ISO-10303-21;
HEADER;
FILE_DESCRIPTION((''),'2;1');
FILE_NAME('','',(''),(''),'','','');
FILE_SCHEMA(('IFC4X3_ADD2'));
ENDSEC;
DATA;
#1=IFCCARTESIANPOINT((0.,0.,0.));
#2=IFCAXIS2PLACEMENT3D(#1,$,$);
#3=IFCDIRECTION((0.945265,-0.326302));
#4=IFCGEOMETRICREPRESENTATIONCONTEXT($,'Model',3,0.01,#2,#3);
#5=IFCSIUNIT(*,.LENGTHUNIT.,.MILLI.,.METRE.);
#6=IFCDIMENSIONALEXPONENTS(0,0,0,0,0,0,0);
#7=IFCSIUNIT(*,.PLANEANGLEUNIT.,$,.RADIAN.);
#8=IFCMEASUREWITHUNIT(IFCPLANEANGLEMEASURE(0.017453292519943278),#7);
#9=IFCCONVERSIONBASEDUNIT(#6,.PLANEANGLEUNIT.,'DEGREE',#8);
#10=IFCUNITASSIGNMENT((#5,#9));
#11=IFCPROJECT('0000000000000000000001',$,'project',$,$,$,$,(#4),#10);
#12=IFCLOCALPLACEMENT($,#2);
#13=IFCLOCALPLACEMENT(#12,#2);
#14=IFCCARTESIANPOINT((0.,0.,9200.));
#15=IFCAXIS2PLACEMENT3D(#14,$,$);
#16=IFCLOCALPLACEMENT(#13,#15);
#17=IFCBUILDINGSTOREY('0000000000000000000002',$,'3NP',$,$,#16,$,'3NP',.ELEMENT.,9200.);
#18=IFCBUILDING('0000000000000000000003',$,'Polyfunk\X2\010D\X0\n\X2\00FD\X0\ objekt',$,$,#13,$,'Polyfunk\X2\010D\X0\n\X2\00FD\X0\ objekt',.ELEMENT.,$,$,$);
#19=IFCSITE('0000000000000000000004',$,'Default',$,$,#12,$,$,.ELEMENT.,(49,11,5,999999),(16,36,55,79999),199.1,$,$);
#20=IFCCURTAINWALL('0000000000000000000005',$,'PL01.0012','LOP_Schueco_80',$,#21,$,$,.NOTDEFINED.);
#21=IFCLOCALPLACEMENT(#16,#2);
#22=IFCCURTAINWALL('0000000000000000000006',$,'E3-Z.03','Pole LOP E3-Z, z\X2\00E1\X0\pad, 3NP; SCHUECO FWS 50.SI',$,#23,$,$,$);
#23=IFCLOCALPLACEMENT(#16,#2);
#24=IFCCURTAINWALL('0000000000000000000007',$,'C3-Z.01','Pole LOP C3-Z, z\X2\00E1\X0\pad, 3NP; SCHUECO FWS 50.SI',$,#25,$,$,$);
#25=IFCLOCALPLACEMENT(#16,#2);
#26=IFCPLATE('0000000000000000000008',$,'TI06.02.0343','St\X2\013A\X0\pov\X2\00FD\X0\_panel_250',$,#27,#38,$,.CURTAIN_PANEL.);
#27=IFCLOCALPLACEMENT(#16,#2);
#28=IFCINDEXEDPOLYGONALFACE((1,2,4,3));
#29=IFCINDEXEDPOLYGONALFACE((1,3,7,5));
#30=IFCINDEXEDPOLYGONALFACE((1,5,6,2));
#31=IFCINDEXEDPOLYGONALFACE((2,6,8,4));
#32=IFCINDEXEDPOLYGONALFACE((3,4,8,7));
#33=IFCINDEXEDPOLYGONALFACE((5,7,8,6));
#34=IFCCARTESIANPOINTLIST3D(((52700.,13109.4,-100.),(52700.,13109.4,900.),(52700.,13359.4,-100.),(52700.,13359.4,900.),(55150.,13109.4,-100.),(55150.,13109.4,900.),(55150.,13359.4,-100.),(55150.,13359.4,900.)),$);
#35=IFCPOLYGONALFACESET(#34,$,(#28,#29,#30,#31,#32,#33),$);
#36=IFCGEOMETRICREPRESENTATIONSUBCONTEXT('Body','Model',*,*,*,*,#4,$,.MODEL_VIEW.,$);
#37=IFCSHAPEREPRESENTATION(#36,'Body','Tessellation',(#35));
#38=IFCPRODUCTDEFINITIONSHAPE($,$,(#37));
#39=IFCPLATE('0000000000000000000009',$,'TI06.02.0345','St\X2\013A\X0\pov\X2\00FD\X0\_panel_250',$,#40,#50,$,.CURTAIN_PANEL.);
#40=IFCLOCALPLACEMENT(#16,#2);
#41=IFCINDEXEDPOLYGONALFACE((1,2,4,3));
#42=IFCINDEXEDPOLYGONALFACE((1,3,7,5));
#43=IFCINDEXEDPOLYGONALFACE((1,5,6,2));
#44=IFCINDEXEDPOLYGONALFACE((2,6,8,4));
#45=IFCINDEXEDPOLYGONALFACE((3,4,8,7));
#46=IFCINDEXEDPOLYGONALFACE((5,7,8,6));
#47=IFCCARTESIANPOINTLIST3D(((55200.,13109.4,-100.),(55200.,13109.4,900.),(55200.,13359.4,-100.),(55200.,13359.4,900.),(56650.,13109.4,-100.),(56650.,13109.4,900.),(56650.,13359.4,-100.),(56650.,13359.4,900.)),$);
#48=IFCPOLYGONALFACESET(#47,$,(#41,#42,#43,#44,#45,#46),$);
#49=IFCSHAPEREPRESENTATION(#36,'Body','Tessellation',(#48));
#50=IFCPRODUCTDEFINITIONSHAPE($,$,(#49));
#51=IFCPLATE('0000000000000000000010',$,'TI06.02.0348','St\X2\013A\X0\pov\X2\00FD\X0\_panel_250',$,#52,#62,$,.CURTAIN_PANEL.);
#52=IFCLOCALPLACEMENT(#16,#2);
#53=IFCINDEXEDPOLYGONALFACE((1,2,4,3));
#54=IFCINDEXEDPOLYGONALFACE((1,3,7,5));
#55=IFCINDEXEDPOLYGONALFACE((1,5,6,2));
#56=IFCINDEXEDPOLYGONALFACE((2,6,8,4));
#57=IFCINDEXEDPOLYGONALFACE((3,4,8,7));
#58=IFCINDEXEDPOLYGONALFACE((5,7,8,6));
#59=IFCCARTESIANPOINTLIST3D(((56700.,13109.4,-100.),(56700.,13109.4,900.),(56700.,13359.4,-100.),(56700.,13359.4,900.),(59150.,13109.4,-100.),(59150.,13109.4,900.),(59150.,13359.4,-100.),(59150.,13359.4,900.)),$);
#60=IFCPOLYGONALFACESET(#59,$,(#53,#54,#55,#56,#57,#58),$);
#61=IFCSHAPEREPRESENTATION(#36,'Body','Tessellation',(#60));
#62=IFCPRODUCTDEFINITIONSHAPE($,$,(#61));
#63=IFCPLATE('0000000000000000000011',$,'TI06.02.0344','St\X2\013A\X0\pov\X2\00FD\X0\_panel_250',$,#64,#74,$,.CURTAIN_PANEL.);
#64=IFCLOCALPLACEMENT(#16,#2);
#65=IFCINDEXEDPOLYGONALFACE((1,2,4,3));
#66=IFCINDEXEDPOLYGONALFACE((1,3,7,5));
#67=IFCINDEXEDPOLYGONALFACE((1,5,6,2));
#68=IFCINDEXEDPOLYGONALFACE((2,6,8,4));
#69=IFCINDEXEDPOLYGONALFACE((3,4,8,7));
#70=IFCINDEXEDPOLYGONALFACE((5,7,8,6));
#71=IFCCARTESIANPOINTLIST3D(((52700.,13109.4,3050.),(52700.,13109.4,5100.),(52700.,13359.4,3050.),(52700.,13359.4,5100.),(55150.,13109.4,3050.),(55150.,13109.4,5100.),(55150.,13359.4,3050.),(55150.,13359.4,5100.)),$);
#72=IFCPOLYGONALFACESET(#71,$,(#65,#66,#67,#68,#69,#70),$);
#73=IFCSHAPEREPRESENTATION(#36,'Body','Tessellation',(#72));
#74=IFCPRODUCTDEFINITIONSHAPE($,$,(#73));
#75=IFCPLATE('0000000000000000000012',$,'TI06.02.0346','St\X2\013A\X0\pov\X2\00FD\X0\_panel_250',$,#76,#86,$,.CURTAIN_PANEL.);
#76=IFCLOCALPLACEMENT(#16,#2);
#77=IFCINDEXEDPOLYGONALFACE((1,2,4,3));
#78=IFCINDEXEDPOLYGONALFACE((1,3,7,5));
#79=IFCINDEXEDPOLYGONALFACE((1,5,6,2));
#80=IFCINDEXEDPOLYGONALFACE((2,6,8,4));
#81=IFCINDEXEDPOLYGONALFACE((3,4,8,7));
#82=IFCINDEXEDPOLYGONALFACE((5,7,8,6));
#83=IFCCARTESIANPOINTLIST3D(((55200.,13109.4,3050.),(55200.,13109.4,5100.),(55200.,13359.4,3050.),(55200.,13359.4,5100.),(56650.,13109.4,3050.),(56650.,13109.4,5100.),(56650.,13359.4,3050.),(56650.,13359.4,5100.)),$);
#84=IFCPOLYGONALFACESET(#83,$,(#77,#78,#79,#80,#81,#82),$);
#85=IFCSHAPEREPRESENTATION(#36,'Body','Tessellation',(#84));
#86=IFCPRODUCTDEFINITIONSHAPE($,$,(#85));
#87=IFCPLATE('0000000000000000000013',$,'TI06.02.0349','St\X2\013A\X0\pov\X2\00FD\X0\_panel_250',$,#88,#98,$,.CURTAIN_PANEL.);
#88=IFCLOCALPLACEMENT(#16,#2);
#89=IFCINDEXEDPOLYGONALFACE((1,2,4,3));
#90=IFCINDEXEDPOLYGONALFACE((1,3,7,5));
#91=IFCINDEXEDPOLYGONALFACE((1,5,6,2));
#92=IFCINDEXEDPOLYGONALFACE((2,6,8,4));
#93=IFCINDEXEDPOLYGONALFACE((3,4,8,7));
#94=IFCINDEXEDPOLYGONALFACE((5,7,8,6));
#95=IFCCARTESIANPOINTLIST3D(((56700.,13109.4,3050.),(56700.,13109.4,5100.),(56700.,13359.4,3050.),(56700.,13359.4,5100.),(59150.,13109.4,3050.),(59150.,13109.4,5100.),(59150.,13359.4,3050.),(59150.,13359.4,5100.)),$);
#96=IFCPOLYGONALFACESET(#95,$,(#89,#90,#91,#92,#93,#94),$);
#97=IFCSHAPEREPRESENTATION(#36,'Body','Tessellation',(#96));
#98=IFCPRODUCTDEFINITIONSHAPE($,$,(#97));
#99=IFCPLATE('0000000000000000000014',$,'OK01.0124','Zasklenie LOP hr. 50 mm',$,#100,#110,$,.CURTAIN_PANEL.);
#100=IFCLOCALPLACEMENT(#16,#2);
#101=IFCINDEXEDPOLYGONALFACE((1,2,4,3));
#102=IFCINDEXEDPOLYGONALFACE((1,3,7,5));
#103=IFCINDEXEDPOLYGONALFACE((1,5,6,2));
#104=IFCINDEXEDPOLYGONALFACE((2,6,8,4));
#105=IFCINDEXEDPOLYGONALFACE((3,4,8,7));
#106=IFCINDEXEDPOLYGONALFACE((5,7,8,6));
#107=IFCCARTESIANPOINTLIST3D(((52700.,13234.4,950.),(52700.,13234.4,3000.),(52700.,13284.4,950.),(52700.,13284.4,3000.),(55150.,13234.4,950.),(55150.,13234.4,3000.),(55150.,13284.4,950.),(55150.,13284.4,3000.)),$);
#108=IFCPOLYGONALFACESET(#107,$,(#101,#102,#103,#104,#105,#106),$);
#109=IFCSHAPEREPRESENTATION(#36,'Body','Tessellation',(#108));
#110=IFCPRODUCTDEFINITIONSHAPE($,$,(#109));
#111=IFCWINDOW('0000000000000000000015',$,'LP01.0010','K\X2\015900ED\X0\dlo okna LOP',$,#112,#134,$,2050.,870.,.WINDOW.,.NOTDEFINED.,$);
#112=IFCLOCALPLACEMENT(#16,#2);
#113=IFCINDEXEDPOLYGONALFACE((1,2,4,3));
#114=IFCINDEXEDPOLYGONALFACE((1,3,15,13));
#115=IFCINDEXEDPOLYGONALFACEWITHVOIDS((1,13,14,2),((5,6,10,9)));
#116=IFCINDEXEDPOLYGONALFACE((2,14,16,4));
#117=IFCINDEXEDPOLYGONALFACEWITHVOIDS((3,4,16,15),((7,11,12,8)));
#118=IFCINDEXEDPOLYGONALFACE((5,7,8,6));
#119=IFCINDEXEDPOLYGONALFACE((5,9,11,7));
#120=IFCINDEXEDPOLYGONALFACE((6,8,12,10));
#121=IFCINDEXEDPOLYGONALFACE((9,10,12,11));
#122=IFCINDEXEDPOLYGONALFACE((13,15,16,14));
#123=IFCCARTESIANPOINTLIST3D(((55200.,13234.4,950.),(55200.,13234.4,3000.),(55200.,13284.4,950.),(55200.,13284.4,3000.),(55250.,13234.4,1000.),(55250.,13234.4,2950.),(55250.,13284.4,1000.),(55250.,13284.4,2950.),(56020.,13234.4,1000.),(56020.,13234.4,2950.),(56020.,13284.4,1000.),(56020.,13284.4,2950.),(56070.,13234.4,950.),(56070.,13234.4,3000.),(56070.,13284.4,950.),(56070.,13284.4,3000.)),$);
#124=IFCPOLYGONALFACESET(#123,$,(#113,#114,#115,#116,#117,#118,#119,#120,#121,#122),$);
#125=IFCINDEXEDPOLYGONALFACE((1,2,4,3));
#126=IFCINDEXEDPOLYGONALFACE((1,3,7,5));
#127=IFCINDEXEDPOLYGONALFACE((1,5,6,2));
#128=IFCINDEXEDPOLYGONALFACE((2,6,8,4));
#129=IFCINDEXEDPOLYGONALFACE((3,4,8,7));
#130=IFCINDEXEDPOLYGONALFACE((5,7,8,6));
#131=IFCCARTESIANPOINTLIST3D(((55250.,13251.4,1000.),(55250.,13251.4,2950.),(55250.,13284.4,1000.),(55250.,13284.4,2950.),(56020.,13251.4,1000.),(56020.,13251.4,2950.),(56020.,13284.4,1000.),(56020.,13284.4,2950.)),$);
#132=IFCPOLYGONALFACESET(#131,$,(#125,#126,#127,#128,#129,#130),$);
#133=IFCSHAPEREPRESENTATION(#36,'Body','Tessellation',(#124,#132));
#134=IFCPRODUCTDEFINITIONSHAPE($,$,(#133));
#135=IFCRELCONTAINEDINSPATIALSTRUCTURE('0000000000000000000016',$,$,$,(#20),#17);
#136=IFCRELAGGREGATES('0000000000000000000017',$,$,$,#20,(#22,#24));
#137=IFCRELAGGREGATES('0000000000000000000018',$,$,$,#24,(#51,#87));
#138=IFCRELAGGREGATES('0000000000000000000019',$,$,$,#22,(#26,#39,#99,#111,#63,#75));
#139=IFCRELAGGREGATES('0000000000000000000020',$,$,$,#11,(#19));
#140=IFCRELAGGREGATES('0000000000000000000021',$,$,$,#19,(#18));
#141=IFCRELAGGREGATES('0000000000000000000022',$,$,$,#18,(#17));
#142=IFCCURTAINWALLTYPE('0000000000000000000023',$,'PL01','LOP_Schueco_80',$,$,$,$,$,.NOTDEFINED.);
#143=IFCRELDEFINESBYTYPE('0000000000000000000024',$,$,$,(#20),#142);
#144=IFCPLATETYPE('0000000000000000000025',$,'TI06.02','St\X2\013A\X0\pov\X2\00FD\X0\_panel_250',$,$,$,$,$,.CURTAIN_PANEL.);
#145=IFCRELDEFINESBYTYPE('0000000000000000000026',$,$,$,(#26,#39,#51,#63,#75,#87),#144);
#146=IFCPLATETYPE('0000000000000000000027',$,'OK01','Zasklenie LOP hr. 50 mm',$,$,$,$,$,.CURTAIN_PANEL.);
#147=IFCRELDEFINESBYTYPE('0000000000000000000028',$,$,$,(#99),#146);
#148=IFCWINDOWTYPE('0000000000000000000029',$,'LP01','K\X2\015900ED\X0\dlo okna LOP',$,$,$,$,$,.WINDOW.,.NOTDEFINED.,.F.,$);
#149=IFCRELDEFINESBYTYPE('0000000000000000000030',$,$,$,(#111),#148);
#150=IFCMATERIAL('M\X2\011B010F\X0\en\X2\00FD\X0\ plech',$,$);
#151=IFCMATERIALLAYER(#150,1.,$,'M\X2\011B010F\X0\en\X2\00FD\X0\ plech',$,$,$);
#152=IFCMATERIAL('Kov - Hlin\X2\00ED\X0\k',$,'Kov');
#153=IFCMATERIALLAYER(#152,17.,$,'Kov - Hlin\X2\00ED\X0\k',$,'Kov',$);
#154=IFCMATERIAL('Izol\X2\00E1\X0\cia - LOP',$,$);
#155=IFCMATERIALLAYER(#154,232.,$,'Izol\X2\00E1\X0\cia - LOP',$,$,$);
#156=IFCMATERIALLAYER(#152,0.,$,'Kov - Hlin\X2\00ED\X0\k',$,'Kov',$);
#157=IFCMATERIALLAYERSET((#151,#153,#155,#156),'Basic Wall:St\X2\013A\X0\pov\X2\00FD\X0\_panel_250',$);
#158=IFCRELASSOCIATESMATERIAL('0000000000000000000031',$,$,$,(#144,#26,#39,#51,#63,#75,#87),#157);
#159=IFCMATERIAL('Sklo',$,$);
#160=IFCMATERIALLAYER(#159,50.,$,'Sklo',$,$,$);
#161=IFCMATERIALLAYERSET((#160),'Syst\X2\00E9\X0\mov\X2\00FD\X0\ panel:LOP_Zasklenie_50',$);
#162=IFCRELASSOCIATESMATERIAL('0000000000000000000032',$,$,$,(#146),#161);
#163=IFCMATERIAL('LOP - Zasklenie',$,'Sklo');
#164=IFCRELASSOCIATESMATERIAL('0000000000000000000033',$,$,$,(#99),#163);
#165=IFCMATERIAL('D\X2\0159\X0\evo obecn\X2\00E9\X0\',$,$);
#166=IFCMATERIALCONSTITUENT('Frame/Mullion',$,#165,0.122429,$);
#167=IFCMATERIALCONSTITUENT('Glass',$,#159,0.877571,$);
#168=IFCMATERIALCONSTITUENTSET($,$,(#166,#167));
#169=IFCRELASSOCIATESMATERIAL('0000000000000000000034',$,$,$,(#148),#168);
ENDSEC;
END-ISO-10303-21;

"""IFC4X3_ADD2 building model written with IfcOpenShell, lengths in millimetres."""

from ifc_helpers import new_model, entity, si_unit, converted_unit, direction, frame, frame_2d, origin, origin_2d_with_axis, place, context, subcontext, project, spatial, polyline, rectangle, outline, extrude, source, transform, mapped, material, layer, layer_set, layer_usage, constituent, constituent_set, type_object, type_shapes, element, aggregate, save


model = new_model("IFC4X3_ADD2")

# Units and contexts
model_context = context("Model", 3, precision=0.01, world=origin(), true_north=direction((0.945265, -0.326302)))
body_context = subcontext(model_context, "Body", "Model", "MODEL_VIEW")
ifc_project = project(units=[si_unit("LENGTHUNIT", "METRE", prefix="MILLI"), converted_unit("PLANEANGLEUNIT", "DEGREE", entity("IfcPlaneAngleMeasure", 0.017453292519943278), si_unit("PLANEANGLEUNIT", "RADIAN"), dimensions=[0, 0, 0, 0, 0, 0, 0])], contexts=[model_context])

# Site, building, storey
site_placement = place(None, origin())
site = spatial("IfcSite", under=ifc_project, at=site_placement, Name="Default", CompositionType="ELEMENT", RefLatitude=(49, 11, 5, 999999), RefLongitude=(16, 36, 55, 79999), RefElevation=199.1)
building_placement = place(site_placement, origin())
building = spatial("IfcBuilding", under=site, at=building_placement, Name="Polyfunkčný objekt", LongName="Polyfunkčný objekt", CompositionType="ELEMENT")
storey_placement = place(building_placement, frame((0.0, 0.0, 9200.0)))
storey = spatial("IfcBuildingStorey", under=building, at=storey_placement, Name="3NP", LongName="3NP", CompositionType="ELEMENT", Elevation=9200.0)

# Curtain walls, plates, window
curtain_wall_type = type_object("IfcCurtainWallType", Name="PL01", Description="LOP_Schueco_80", PredefinedType="NOTDEFINED")
curtain_wall_1_placement = place(storey_placement, frame((0.0, 0.0, -9200.0)))
curtain_wall_1 = element("IfcCurtainWall", 1, at=curtain_wall_1_placement, inside=storey, type_object=curtain_wall_type, Name="PL01.0012", Description="LOP_Schueco_80", PredefinedType="NOTDEFINED")
curtain_wall_2 = element("IfcCurtainWall", 2, Name="E3-Z.03", Description="Pole LOP E3-Z, západ, 3NP; SCHUECO FWS 50.SI")
curtain_wall_3 = element("IfcCurtainWall", 3, Name="C3-Z.01", Description="Pole LOP C3-Z, západ, 3NP; SCHUECO FWS 50.SI")
aggregate(curtain_wall_1, [curtain_wall_2, curtain_wall_3])
ifc_material_1 = material(Name="Měďený plech")
ifc_layer_1 = layer(ifc_material_1, 1.0, Name="Měďený plech")
ifc_material_2 = material(Name="Kov - Hliník", Category="Kov")
ifc_layer_2 = layer(ifc_material_2, 17.0, Name="Kov - Hliník", Category="Kov")
ifc_material_3 = material(Name="Izolácia - LOP")
ifc_layer_3 = layer(ifc_material_3, 232.0, Name="Izolácia - LOP")
ifc_layer_4 = layer(ifc_material_2, 0.0, Name="Kov - Hliník", Category="Kov")
ifc_layer_set_1 = layer_set([ifc_layer_1, ifc_layer_2, ifc_layer_3, ifc_layer_4], Name="Basic Wall:Stĺpový_panel_250")
ifc_layer_usage_1 = layer_usage(ifc_layer_set_1, "AXIS2", "NEGATIVE", 125.0)
plate_type_1 = type_object("IfcPlateType", Name="TI06.02", Description="Stĺpový_panel_250", PredefinedType="CURTAIN_PANEL", material=ifc_layer_set_1)
plate_1_placement = place(storey_placement, frame((52700.0, 13234.4, -100.0)))
plate_1 = element("IfcPlate", 4, at=plate_1_placement, type_object=plate_type_1, material=ifc_layer_usage_1, Name="TI06.02.0343", Description="Stĺpový_panel_250", PredefinedType="CURTAIN_PANEL", context=body_context, shape_type="SweptSolid", body=[
    extrude(rectangle(XDim=250.0, YDim=2450.0, at=origin_2d_with_axis()), frame((1225.0, 0.0, 0.0), z_axis=(0.0, 0.0, 1.0), x_axis=(0.0, 1.0, 0.0)), (0.0, 0.0, 1.0), 1000.0),
])
ifc_layer_usage_2 = layer_usage(ifc_layer_set_1, "AXIS2", "NEGATIVE", 125.0)
plate_2_placement = place(storey_placement, frame((55200.0, 13234.4, -100.0)))
plate_2 = element("IfcPlate", 5, at=plate_2_placement, type_object=plate_type_1, material=ifc_layer_usage_2, Name="TI06.02.0345", Description="Stĺpový_panel_250", PredefinedType="CURTAIN_PANEL", context=body_context, shape_type="SweptSolid", body=[
    extrude(rectangle(XDim=250.0, YDim=1450.0, at=origin_2d_with_axis()), frame((725.0, 0.0, 0.0), z_axis=(0.0, 0.0, 1.0), x_axis=(0.0, 1.0, 0.0)), (0.0, 0.0, 1.0), 1000.0),
])
ifc_layer_usage_3 = layer_usage(ifc_layer_set_1, "AXIS2", "NEGATIVE", 125.0)
plate_3_placement = place(storey_placement, frame((56700.0, 13234.4, -100.0)))
plate_3 = element("IfcPlate", 6, at=plate_3_placement, type_object=plate_type_1, material=ifc_layer_usage_3, Name="TI06.02.0348", Description="Stĺpový_panel_250", PredefinedType="CURTAIN_PANEL", context=body_context, shape_type="SweptSolid", body=[
    extrude(rectangle(XDim=250.0, YDim=2450.0, at=frame_2d((0.0, 0.0), x_axis=(1.0, 0.0))), frame((1225.0, 0.0, 0.0), z_axis=(0.0, 0.0, 1.0), x_axis=(0.0, 1.0, 0.0)), (0.0, 0.0, 1.0), 1000.0),
])
ifc_layer_usage_4 = layer_usage(ifc_layer_set_1, "AXIS2", "NEGATIVE", 125.0)
plate_4_placement = place(storey_placement, frame((52700.0, 13234.4, 3050.0)))
plate_4 = element("IfcPlate", 7, at=plate_4_placement, type_object=plate_type_1, material=ifc_layer_usage_4, Name="TI06.02.0344", Description="Stĺpový_panel_250", PredefinedType="CURTAIN_PANEL", context=body_context, shape_type="SweptSolid", body=[
    extrude(rectangle(XDim=250.0, YDim=2450.0, at=origin_2d_with_axis()), frame((1225.0, 0.0, 0.0), z_axis=(0.0, 0.0, 1.0), x_axis=(0.0, 1.0, 0.0)), (0.0, 0.0, 1.0), 2050.0),
])
ifc_layer_usage_5 = layer_usage(ifc_layer_set_1, "AXIS2", "NEGATIVE", 125.0)
plate_5_placement = place(storey_placement, frame((55200.0, 13234.4, 3050.0)))
plate_5 = element("IfcPlate", 8, at=plate_5_placement, type_object=plate_type_1, material=ifc_layer_usage_5, Name="TI06.02.0346", Description="Stĺpový_panel_250", PredefinedType="CURTAIN_PANEL", context=body_context, shape_type="SweptSolid", body=[
    extrude(rectangle(XDim=250.0, YDim=1450.0, at=origin_2d_with_axis()), frame((725.0, 0.0, 0.0), z_axis=(0.0, 0.0, 1.0), x_axis=(0.0, 1.0, 0.0)), (0.0, 0.0, 1.0), 2050.0),
])
ifc_layer_usage_6 = layer_usage(ifc_layer_set_1, "AXIS2", "NEGATIVE", 125.0)
plate_6_placement = place(storey_placement, frame((56700.0, 13234.4, 3050.0)))
plate_6 = element("IfcPlate", 9, at=plate_6_placement, type_object=plate_type_1, material=ifc_layer_usage_6, Name="TI06.02.0349", Description="Stĺpový_panel_250", PredefinedType="CURTAIN_PANEL", context=body_context, shape_type="SweptSolid", body=[
    extrude(rectangle(XDim=250.0, YDim=2450.0, at=frame_2d((0.0, 0.0), x_axis=(1.0, 0.0))), frame((1225.0, 0.0, 0.0), z_axis=(0.0, 0.0, 1.0), x_axis=(0.0, 1.0, 0.0)), (0.0, 0.0, 1.0), 2050.0),
])
aggregate(curtain_wall_3, [plate_3, plate_6])
ifc_material_4 = material(Name="LOP - Zasklenie", Category="Sklo")
ifc_material_5 = material(Name="Sklo")
ifc_layer_5 = layer(ifc_material_5, 50.0, Name="Sklo")
ifc_layer_set_2 = layer_set([ifc_layer_5], Name="Systémový panel:LOP_Zasklenie_50")
plate_type_2 = type_object("IfcPlateType", Name="OK01", Description="Zasklenie LOP hr. 50 mm", PredefinedType="CURTAIN_PANEL", material=ifc_layer_set_2)
shared_shape_1 = source(origin(), body_context, "Body", "SweptSolid", [
    extrude(rectangle(XDim=50.0, YDim=2450.0, at=origin_2d_with_axis()), frame((0.0, 25.0, 0.0), z_axis=(0.0, 0.0, 1.0), x_axis=(0.0, 1.0, 0.0)), (0.0, 0.0, 1.0), 2050.0),
])
type_shapes(plate_type_2, [shared_shape_1])
plate_7_placement = place(curtain_wall_1_placement, frame((53925.0, 13234.4, 10150.0)))
plate_7 = element("IfcPlate", 10, at=plate_7_placement, type_object=plate_type_2, material=ifc_material_4, Name="OK01.0124", Description="Zasklenie LOP hr. 50 mm", PredefinedType="CURTAIN_PANEL", context=body_context, shape_type="MappedRepresentation", body=[
    mapped(shared_shape_1, transform((0.0, 0.0, 0.0), scale=1.0)),
])
ifc_material_6 = material(Name="Dřevo obecné")
ifc_constituent_1 = constituent(ifc_material_6, Name="Frame/Mullion", fraction=0.122429)
ifc_constituent_2 = constituent(ifc_material_5, Name="Glass", fraction=0.877571)
ifc_constituent_set = constituent_set(constituents=[ifc_constituent_1, ifc_constituent_2])
window_type = type_object("IfcWindowType", Name="LP01", Description="Křídlo okna LOP", ParameterTakesPrecedence=False, PartitioningType="NOTDEFINED", PredefinedType="WINDOW", material=ifc_constituent_set)
shared_shape_2 = source(origin(), body_context, "Body", "SweptSolid", [
    extrude(outline(polyline([(-1025.0, -435.0), (1025.0, -435.0), (1025.0, 435.0), (-1025.0, 435.0), (-1025.0, -435.0)]), holes=[polyline([(-975.0, -385.0), (-975.0, 385.0), (975.0, 385.0), (975.0, -385.0), (-975.0, -385.0)])]), frame((0.0, 0.0, 1025.0), z_axis=(0.0, 1.0, 0.0), x_axis=(0.0, 0.0, -1.0)), (0.0, 0.0, 1.0), 50.0),
    extrude(rectangle(XDim=33.0, YDim=770.0, at=origin_2d_with_axis()), frame((0.0, 33.5, 50.0), z_axis=(0.0, 0.0, 1.0), x_axis=(0.0, -1.0, 0.0)), (0.0, 0.0, 1.0), 1950.0),
])
type_shapes(window_type, [shared_shape_2])
window_placement = place(curtain_wall_1_placement, frame((55635.0, 13234.4, 10150.0)))
window = element("IfcWindow", 11, at=window_placement, type_object=window_type, Name="LP01.0010", Description="Křídlo okna LOP", OverallHeight=2050.0, OverallWidth=870.0, PartitioningType="NOTDEFINED", PredefinedType="WINDOW", context=body_context, shape_type="MappedRepresentation", body=[
    mapped(shared_shape_2, transform((0.0, 0.0, 0.0), scale=1.0)),
])
aggregate(curtain_wall_2, [plate_1, plate_2, plate_7, window, plate_4, plate_5])

save(model, "model.ifc")
